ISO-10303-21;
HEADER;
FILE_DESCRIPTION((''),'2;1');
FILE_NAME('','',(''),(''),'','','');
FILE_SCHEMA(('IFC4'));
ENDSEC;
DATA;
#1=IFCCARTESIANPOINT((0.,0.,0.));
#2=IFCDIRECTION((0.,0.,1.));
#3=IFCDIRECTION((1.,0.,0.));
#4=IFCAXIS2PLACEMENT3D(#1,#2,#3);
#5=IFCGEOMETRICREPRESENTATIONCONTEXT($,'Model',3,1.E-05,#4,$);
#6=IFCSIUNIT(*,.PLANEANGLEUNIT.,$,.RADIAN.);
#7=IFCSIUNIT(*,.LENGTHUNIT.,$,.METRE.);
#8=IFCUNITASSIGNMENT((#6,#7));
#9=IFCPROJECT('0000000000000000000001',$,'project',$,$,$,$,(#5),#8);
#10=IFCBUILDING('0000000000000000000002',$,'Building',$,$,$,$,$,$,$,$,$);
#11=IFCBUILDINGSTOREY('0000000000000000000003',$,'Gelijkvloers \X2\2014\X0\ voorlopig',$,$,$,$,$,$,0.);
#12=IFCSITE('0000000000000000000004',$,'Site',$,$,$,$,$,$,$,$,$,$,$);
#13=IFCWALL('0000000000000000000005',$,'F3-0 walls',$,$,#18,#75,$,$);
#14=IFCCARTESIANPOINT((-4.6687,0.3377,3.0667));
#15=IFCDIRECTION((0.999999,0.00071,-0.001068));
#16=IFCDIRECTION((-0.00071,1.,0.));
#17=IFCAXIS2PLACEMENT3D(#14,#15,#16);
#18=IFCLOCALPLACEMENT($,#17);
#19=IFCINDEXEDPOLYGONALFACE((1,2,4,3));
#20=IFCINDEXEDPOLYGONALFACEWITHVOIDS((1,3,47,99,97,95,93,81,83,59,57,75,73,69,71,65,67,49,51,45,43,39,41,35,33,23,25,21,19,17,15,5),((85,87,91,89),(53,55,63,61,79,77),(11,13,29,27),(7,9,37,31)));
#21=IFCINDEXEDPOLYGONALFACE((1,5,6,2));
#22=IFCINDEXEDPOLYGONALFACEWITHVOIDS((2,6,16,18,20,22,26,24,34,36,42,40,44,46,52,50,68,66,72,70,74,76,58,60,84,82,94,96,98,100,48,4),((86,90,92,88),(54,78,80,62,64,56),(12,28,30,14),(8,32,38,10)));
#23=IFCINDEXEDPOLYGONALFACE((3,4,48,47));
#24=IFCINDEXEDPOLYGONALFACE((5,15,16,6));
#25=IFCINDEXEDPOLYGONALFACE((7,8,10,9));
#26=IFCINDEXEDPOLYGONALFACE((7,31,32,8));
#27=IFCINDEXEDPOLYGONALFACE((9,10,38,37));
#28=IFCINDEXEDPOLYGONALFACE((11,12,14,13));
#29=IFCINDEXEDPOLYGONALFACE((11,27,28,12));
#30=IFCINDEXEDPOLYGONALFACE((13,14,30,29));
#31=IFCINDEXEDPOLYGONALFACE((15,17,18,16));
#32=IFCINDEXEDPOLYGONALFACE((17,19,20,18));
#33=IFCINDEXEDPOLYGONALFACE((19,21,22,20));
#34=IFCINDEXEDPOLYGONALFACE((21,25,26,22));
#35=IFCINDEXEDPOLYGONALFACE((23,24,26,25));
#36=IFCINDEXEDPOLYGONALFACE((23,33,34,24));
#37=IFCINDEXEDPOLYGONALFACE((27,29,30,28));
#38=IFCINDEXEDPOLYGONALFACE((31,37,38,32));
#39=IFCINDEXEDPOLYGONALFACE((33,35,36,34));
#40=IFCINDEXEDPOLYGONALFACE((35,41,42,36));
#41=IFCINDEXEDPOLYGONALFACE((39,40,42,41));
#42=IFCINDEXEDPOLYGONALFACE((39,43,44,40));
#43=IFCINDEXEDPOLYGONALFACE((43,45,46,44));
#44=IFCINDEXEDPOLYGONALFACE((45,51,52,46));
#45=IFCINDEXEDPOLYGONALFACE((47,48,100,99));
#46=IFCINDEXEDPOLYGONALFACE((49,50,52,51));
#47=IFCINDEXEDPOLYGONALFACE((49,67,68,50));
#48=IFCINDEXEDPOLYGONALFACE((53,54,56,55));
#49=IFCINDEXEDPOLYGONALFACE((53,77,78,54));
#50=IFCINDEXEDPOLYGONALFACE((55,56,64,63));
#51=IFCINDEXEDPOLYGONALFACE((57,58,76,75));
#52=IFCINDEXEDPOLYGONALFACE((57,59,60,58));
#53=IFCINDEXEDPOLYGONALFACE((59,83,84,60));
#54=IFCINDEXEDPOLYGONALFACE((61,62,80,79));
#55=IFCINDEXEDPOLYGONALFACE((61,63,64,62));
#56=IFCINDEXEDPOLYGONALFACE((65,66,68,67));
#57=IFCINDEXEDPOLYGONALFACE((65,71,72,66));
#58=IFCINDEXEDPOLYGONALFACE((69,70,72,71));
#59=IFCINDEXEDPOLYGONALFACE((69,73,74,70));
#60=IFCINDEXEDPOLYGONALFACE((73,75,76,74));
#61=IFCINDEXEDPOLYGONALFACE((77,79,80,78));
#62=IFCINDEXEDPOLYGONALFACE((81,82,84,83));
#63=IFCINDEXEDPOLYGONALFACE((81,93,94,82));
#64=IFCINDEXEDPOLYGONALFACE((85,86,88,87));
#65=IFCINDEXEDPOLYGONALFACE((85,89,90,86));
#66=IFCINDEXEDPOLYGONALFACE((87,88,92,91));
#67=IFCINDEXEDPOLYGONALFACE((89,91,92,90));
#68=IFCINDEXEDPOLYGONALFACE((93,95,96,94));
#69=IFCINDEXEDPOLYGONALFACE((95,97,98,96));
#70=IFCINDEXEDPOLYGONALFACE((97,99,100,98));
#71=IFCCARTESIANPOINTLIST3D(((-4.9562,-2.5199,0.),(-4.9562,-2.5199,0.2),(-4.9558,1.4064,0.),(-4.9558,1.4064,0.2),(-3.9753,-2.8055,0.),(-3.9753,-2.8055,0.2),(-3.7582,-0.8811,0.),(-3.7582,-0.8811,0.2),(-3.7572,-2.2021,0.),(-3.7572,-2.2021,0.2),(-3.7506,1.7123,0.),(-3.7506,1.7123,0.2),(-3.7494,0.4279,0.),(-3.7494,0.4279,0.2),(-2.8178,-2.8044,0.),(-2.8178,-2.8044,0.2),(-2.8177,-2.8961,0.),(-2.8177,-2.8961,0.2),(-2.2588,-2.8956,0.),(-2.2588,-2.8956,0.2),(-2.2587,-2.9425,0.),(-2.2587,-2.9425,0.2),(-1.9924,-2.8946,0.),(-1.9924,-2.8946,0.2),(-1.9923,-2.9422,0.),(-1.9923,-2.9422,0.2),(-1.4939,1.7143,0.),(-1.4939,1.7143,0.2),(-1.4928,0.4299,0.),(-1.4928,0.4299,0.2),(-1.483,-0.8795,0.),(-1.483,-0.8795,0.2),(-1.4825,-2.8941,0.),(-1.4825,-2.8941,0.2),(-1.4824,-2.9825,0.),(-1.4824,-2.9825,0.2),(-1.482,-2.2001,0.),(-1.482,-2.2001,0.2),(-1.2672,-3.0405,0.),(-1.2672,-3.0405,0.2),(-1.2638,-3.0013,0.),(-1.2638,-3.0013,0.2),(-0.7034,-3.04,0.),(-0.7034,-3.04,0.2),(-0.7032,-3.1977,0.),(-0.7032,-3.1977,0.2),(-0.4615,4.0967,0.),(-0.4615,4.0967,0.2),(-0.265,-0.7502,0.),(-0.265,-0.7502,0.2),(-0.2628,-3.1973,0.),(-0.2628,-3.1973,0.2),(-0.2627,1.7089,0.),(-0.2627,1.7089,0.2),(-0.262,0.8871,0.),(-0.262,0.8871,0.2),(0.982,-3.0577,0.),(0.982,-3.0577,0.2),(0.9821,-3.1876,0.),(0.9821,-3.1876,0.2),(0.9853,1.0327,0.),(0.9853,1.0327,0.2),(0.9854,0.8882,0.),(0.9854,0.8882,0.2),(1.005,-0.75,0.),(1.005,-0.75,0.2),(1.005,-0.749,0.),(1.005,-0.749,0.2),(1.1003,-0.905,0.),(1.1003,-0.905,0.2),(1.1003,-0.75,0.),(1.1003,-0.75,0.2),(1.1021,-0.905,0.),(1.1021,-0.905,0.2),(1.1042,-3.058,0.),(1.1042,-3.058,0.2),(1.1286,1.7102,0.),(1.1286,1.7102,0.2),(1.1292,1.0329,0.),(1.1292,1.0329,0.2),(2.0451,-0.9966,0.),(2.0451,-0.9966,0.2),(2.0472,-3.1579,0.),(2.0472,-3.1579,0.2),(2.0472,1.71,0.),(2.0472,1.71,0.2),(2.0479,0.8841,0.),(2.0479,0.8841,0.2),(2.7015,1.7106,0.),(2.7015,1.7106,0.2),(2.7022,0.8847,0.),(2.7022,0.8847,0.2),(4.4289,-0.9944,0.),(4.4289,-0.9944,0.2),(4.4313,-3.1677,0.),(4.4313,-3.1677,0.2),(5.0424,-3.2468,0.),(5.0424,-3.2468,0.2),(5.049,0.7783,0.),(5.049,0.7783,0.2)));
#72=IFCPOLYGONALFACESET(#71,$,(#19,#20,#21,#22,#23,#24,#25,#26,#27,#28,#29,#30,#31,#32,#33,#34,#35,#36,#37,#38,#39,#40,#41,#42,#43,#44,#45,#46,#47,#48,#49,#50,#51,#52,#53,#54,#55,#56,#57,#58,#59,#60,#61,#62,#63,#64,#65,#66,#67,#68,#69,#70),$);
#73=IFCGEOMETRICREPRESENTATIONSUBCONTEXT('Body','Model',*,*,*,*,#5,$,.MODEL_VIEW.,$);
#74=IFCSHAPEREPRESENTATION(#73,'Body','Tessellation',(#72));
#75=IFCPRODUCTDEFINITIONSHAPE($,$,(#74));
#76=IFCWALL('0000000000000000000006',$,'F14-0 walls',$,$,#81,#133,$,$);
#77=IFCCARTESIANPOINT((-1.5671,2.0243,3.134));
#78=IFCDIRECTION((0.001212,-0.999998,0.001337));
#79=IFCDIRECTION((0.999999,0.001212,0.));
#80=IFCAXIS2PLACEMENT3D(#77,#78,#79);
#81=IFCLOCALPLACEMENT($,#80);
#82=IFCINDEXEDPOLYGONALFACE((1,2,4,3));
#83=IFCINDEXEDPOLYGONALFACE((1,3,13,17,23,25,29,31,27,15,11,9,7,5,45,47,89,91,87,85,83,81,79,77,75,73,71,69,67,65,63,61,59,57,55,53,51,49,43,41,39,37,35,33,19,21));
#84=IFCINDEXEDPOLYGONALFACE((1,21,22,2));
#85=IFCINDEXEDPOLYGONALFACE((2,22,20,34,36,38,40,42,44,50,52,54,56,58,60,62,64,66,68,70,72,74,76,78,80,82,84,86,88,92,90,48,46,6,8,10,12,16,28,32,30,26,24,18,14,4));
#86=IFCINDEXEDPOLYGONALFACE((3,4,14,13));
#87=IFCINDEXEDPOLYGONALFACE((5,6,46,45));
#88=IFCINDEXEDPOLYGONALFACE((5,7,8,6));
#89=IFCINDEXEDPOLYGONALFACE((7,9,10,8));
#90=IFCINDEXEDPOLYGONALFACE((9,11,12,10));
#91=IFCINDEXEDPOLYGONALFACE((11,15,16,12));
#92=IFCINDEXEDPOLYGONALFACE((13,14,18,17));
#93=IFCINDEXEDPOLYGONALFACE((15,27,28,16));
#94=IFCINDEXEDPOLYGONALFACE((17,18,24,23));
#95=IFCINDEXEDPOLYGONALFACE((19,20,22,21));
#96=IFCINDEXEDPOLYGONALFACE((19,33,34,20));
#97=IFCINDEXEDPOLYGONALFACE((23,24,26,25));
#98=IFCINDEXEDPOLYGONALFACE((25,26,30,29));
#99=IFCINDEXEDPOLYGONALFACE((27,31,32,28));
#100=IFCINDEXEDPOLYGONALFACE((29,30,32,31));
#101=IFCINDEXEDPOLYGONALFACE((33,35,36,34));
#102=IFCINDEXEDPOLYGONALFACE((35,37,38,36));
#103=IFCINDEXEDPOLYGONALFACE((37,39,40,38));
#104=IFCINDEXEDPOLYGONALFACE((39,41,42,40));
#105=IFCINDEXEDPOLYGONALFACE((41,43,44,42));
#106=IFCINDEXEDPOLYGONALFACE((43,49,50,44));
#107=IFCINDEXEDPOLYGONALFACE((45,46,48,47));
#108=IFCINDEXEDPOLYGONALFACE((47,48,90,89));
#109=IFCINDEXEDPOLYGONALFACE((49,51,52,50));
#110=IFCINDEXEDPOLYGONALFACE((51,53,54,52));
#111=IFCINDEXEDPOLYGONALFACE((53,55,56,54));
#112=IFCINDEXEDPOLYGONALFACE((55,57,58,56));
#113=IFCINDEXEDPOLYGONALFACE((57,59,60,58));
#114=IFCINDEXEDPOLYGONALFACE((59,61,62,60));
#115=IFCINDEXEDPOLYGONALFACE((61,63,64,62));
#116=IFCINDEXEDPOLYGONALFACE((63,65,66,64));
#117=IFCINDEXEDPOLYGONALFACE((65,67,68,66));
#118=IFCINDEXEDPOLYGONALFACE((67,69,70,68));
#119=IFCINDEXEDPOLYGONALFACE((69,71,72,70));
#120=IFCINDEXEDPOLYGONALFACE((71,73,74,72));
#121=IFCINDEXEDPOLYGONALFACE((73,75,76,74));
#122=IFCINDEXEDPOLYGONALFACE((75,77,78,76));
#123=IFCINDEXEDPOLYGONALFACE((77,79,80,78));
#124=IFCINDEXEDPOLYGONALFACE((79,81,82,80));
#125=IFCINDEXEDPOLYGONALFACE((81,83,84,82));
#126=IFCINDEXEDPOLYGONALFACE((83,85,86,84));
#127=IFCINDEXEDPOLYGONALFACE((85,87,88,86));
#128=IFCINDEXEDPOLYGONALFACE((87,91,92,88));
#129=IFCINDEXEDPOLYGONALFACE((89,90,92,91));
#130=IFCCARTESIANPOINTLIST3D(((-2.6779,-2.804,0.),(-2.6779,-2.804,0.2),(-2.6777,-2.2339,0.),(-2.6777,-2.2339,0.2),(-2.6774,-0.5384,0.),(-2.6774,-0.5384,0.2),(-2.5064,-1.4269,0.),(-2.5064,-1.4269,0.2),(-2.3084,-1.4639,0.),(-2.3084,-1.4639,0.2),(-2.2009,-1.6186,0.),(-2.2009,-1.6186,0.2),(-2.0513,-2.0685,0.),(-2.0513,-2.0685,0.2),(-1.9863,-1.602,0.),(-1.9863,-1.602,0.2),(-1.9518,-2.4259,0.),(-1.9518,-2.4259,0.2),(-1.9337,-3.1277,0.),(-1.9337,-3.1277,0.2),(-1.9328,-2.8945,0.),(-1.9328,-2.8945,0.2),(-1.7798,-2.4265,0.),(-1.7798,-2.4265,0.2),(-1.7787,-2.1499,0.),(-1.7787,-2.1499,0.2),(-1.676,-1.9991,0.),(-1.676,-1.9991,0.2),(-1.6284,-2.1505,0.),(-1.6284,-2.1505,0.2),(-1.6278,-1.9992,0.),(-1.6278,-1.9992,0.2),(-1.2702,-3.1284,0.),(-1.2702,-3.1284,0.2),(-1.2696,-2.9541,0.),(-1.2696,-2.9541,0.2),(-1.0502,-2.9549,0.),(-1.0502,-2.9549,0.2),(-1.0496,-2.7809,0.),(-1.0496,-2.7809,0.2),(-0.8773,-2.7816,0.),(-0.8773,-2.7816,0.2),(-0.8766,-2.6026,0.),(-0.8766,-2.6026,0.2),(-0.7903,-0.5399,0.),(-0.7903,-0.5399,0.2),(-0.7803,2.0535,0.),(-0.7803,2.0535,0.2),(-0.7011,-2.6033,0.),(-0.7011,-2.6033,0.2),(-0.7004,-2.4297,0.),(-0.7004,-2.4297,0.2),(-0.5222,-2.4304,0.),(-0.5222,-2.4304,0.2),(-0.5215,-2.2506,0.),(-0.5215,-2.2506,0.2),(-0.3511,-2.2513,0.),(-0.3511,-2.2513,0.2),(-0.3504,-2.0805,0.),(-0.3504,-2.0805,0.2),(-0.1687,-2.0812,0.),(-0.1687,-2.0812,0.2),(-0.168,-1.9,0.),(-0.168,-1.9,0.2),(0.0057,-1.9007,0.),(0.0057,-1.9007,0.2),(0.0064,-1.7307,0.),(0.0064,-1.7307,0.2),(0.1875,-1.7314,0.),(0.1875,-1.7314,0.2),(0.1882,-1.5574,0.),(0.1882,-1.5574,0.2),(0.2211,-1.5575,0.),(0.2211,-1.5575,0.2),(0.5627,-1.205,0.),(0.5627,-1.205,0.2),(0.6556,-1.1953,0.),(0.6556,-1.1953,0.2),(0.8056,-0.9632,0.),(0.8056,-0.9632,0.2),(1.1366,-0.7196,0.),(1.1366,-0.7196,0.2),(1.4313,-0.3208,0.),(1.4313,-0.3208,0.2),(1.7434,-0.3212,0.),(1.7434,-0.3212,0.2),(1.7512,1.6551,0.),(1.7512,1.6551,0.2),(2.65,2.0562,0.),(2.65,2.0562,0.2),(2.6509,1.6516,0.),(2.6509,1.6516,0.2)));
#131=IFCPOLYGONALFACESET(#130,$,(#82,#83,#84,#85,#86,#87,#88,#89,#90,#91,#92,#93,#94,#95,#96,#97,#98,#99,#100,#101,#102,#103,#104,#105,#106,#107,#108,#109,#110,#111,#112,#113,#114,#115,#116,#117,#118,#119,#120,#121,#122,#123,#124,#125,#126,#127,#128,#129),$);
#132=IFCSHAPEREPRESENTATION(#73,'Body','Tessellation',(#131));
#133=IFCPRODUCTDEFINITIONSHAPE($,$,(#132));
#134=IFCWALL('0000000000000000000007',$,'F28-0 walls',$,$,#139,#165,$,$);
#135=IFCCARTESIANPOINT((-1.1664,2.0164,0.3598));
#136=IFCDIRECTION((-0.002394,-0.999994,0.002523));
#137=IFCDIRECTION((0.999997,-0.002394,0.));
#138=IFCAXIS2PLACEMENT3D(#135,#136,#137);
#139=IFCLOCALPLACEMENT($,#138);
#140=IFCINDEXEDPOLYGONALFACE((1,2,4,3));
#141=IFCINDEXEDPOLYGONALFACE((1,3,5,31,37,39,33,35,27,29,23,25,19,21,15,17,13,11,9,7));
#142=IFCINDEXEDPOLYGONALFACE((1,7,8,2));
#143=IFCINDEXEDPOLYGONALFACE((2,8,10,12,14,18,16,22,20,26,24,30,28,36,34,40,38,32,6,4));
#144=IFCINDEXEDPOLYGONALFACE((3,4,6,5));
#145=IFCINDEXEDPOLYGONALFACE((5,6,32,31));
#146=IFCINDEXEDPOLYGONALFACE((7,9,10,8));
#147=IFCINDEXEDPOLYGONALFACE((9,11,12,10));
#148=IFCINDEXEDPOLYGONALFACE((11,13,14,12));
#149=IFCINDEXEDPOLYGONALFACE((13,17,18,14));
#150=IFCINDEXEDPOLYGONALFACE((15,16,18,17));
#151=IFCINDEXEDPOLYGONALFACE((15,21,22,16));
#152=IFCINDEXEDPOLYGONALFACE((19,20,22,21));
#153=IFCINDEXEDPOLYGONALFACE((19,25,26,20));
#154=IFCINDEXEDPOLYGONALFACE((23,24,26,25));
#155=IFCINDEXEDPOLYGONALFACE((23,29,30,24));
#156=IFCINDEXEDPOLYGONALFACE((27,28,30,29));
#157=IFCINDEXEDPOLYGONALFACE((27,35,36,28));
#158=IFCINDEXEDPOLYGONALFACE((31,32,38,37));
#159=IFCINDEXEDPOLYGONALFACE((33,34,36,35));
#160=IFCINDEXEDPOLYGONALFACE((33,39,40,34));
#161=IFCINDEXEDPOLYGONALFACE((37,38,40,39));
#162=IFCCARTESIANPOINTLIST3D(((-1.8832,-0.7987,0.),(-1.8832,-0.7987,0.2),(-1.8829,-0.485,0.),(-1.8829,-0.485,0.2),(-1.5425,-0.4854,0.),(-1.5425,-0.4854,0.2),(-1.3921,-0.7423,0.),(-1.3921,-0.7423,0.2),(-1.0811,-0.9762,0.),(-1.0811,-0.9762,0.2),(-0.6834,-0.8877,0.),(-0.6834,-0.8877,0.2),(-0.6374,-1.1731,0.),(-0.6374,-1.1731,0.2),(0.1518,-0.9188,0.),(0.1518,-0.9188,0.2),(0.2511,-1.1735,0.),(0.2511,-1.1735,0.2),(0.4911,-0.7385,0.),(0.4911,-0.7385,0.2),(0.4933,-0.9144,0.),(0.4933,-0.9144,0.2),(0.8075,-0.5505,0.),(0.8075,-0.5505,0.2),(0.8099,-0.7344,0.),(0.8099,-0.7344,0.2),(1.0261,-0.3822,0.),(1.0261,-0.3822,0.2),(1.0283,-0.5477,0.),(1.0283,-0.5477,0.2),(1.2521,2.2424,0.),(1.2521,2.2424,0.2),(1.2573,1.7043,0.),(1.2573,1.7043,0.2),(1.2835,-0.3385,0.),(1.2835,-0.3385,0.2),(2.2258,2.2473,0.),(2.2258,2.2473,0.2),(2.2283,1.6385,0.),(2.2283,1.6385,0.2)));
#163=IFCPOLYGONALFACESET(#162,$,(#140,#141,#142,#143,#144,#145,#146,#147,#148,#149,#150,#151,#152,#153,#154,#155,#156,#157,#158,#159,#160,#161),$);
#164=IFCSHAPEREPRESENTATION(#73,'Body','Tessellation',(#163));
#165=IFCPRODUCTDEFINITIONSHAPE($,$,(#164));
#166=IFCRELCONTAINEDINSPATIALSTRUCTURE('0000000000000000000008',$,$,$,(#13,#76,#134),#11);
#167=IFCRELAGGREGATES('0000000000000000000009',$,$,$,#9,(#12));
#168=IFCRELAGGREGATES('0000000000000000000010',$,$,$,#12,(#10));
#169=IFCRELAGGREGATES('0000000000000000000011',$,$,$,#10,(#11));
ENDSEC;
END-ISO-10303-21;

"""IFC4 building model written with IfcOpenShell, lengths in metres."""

from ifc_helpers import new_model, si_unit, frame, origin_with_axes, place, context, subcontext, project, spatial, polyline, outline, extrude, element, save


model = new_model("IFC4")

# Units and contexts
model_context = context("Model", 3, precision=1e-05, world=origin_with_axes())
body_context = subcontext(model_context, "Body", "Model", "MODEL_VIEW")
ifc_project = project(units=[si_unit("PLANEANGLEUNIT", "RADIAN"), si_unit("LENGTHUNIT", "METRE")], contexts=[model_context])

# Site, building, storey
site = spatial("IfcSite", under=ifc_project, Name="Site")
building = spatial("IfcBuilding", under=site, Name="Building")
storey = spatial("IfcBuildingStorey", under=building, Name="Gelijkvloers — voorlopig", Elevation=0.0)

# Wall, openings
wall_1_placement = place(None, frame((-4.6687, 0.3377, 3.0667), z_axis=(0.999999, 0.00071, -0.001068), x_axis=(-0.00071, 1.0, 0.0)))
wall_1 = element("IfcWall", 1, at=wall_1_placement, inside=storey, Name="F3-0 walls", context=body_context, shape_type="SweptSolid", body=[
    extrude(outline(polyline([(4.4313, -3.1677), (5.0424, -3.2468), (5.049, 0.7783), (-0.4615, 4.0967), (-4.9558, 1.4064), (-4.9562, -2.5199), (-3.9753, -2.8055), (-2.8178, -2.8044), (-2.8177, -2.8961), (-2.2588, -2.8956), (-2.2587, -2.9425), (-1.9923, -2.9422), (-1.9924, -2.8946), (-1.4825, -2.8941), (-1.4824, -2.9825), (-1.2638, -3.0013), (-1.2672, -3.0405), (-0.7034, -3.04), (-0.7032, -3.1977), (-0.2628, -3.1973), (-0.265, -0.7502), (1.005, -0.749), (1.0051, -0.9051), (1.1021, -0.905), (1.1042, -3.058), (0.982, -3.0577), (0.9821, -3.1876), (2.0472, -3.1579), (2.0451, -0.9966), (4.4289, -0.9944), (4.4313, -3.1677)])), origin_with_axes(), (0.0, 0.0, 1.0), 0.2),
])
opening_1_placement = place(wall_1_placement, frame((0.0, 0.0, -0.05), z_axis=(0.0, 0.0, 1.0), x_axis=(1.0, 0.0, 0.0)))
element("IfcOpeningElement", 2, at=opening_1_placement, cuts=wall_1, PredefinedType="OPENING", context=body_context, shape_type="SweptSolid", body=[
    extrude(outline(polyline([(-0.2627, -3.0666), (-0.2627, -0.7509), (1.1003, -0.75), (1.1007, -3.0567), (-0.2627, -3.0666)])), origin_with_axes(), (0.0, 0.0, 1.0), 0.3),
])
opening_2_placement = place(wall_1_placement, frame((0.0, 0.0, -0.05), z_axis=(0.0, 0.0, 1.0), x_axis=(1.0, 0.0, 0.0)))
element("IfcOpeningElement", 3, at=opening_2_placement, cuts=wall_1, PredefinedType="OPENING", context=body_context, shape_type="SweptSolid", body=[
    extrude(outline(polyline([(-3.7572, -2.2021), (-3.7582, -0.8811), (-1.483, -0.8795), (-1.482, -2.2001), (-3.7572, -2.2021)])), origin_with_axes(), (0.0, 0.0, 1.0), 0.3),
])
opening_3_placement = place(wall_1_placement, frame((0.0, 0.0, -0.05), z_axis=(0.0, 0.0, 1.0), x_axis=(1.0, 0.0, 0.0)))
element("IfcOpeningElement", 4, at=opening_3_placement, cuts=wall_1, PredefinedType="OPENING", context=body_context, shape_type="SweptSolid", body=[
    extrude(outline(polyline([(-1.4939, 1.7143), (-1.4928, 0.4299), (-3.7494, 0.4279), (-3.7506, 1.7123), (-1.4939, 1.7143)])), origin_with_axes(), (0.0, 0.0, 1.0), 0.3),
])
opening_4_placement = place(wall_1_placement, frame((0.0, 0.0, -0.05), z_axis=(0.0, 0.0, 1.0), x_axis=(1.0, 0.0, 0.0)))
element("IfcOpeningElement", 5, at=opening_4_placement, cuts=wall_1, PredefinedType="OPENING", context=body_context, shape_type="SweptSolid", body=[
    extrude(outline(polyline([(2.7022, 0.8847), (2.0479, 0.8841), (2.0472, 1.71), (2.7015, 1.7106), (2.7022, 0.8847)])), origin_with_axes(), (0.0, 0.0, 1.0), 0.3),
])
opening_5_placement = place(wall_1_placement, frame((0.0, 0.0, -0.05), z_axis=(0.0, 0.0, 1.0), x_axis=(1.0, 0.0, 0.0)))
element("IfcOpeningElement", 6, at=opening_5_placement, cuts=wall_1, PredefinedType="OPENING", context=body_context, shape_type="SweptSolid", body=[
    extrude(outline(polyline([(1.1292, 1.0329), (0.9853, 1.0327), (0.9854, 0.8882), (-0.262, 0.8871), (-0.2627, 1.7089), (1.1286, 1.7102), (1.1292, 1.0329)])), origin_with_axes(), (0.0, 0.0, 1.0), 0.3),
])

# Walls
wall_2_placement = place(None, frame((-1.5671, 2.0243, 3.134), z_axis=(0.001212, -0.999998, 0.001337), x_axis=(0.999999, 0.001212, 0.0)))
element("IfcWall", 7, at=wall_2_placement, inside=storey, Name="F14-0 walls", context=body_context, shape_type="SweptSolid", body=[
    extrude(outline(polyline([(-1.2702, -3.1284), (-1.2696, -2.9541), (-1.0502, -2.9549), (-1.0496, -2.7809), (-0.8773, -2.7816), (-0.8766, -2.6026), (-0.7011, -2.6033), (-0.7004, -2.4297), (-0.5222, -2.4304), (-0.5215, -2.2506), (-0.3511, -2.2513), (-0.3504, -2.0805), (-0.1687, -2.0812), (-0.168, -1.9), (0.0057, -1.9007), (0.0064, -1.7307), (0.1875, -1.7314), (0.1882, -1.5574), (0.2211, -1.5575), (0.5627, -1.205), (0.6556, -1.1953), (0.8056, -0.9632), (1.1366, -0.7196), (1.4313, -0.3208), (1.7434, -0.3212), (1.7512, 1.6551), (2.6509, 1.6516), (2.65, 2.0562), (-0.7803, 2.0535), (-0.7903, -0.5399), (-2.6774, -0.5384), (-2.5064, -1.4269), (-2.3084, -1.4639), (-2.2009, -1.6186), (-1.9863, -1.602), (-1.676, -1.9991), (-1.6278, -1.9992), (-1.6284, -2.1505), (-1.7787, -2.1499), (-1.7798, -2.4265), (-1.9518, -2.4259), (-2.0513, -2.0685), (-2.6777, -2.2339), (-2.6779, -2.804), (-1.9328, -2.8945), (-1.9337, -3.1277), (-1.2702, -3.1284)])), origin_with_axes(), (0.0, 0.0, 1.0), 0.2),
])
wall_3_placement = place(None, frame((-1.1664, 2.0164, 0.3598), z_axis=(-0.002394, -0.999994, 0.002523), x_axis=(0.999997, -0.002394, 0.0)))
element("IfcWall", 8, at=wall_3_placement, inside=storey, Name="F28-0 walls", context=body_context, shape_type="SweptSolid", body=[
    extrude(outline(polyline([(-0.6374, -1.1731), (0.2511, -1.1735), (0.1518, -0.9188), (0.4933, -0.9144), (0.4911, -0.7385), (0.8099, -0.7344), (0.8075, -0.5505), (1.0283, -0.5477), (1.0261, -0.3822), (1.2835, -0.3385), (1.2573, 1.7043), (2.2283, 1.6385), (2.2258, 2.2473), (1.2521, 2.2424), (-1.5425, -0.4854), (-1.8829, -0.485), (-1.8832, -0.7987), (-1.3921, -0.7423), (-1.0811, -0.9762), (-0.6834, -0.8877), (-0.6374, -1.1731)])), origin_with_axes(), (0.0, 0.0, 1.0), 0.2),
])

save(model, "model.ifc")
